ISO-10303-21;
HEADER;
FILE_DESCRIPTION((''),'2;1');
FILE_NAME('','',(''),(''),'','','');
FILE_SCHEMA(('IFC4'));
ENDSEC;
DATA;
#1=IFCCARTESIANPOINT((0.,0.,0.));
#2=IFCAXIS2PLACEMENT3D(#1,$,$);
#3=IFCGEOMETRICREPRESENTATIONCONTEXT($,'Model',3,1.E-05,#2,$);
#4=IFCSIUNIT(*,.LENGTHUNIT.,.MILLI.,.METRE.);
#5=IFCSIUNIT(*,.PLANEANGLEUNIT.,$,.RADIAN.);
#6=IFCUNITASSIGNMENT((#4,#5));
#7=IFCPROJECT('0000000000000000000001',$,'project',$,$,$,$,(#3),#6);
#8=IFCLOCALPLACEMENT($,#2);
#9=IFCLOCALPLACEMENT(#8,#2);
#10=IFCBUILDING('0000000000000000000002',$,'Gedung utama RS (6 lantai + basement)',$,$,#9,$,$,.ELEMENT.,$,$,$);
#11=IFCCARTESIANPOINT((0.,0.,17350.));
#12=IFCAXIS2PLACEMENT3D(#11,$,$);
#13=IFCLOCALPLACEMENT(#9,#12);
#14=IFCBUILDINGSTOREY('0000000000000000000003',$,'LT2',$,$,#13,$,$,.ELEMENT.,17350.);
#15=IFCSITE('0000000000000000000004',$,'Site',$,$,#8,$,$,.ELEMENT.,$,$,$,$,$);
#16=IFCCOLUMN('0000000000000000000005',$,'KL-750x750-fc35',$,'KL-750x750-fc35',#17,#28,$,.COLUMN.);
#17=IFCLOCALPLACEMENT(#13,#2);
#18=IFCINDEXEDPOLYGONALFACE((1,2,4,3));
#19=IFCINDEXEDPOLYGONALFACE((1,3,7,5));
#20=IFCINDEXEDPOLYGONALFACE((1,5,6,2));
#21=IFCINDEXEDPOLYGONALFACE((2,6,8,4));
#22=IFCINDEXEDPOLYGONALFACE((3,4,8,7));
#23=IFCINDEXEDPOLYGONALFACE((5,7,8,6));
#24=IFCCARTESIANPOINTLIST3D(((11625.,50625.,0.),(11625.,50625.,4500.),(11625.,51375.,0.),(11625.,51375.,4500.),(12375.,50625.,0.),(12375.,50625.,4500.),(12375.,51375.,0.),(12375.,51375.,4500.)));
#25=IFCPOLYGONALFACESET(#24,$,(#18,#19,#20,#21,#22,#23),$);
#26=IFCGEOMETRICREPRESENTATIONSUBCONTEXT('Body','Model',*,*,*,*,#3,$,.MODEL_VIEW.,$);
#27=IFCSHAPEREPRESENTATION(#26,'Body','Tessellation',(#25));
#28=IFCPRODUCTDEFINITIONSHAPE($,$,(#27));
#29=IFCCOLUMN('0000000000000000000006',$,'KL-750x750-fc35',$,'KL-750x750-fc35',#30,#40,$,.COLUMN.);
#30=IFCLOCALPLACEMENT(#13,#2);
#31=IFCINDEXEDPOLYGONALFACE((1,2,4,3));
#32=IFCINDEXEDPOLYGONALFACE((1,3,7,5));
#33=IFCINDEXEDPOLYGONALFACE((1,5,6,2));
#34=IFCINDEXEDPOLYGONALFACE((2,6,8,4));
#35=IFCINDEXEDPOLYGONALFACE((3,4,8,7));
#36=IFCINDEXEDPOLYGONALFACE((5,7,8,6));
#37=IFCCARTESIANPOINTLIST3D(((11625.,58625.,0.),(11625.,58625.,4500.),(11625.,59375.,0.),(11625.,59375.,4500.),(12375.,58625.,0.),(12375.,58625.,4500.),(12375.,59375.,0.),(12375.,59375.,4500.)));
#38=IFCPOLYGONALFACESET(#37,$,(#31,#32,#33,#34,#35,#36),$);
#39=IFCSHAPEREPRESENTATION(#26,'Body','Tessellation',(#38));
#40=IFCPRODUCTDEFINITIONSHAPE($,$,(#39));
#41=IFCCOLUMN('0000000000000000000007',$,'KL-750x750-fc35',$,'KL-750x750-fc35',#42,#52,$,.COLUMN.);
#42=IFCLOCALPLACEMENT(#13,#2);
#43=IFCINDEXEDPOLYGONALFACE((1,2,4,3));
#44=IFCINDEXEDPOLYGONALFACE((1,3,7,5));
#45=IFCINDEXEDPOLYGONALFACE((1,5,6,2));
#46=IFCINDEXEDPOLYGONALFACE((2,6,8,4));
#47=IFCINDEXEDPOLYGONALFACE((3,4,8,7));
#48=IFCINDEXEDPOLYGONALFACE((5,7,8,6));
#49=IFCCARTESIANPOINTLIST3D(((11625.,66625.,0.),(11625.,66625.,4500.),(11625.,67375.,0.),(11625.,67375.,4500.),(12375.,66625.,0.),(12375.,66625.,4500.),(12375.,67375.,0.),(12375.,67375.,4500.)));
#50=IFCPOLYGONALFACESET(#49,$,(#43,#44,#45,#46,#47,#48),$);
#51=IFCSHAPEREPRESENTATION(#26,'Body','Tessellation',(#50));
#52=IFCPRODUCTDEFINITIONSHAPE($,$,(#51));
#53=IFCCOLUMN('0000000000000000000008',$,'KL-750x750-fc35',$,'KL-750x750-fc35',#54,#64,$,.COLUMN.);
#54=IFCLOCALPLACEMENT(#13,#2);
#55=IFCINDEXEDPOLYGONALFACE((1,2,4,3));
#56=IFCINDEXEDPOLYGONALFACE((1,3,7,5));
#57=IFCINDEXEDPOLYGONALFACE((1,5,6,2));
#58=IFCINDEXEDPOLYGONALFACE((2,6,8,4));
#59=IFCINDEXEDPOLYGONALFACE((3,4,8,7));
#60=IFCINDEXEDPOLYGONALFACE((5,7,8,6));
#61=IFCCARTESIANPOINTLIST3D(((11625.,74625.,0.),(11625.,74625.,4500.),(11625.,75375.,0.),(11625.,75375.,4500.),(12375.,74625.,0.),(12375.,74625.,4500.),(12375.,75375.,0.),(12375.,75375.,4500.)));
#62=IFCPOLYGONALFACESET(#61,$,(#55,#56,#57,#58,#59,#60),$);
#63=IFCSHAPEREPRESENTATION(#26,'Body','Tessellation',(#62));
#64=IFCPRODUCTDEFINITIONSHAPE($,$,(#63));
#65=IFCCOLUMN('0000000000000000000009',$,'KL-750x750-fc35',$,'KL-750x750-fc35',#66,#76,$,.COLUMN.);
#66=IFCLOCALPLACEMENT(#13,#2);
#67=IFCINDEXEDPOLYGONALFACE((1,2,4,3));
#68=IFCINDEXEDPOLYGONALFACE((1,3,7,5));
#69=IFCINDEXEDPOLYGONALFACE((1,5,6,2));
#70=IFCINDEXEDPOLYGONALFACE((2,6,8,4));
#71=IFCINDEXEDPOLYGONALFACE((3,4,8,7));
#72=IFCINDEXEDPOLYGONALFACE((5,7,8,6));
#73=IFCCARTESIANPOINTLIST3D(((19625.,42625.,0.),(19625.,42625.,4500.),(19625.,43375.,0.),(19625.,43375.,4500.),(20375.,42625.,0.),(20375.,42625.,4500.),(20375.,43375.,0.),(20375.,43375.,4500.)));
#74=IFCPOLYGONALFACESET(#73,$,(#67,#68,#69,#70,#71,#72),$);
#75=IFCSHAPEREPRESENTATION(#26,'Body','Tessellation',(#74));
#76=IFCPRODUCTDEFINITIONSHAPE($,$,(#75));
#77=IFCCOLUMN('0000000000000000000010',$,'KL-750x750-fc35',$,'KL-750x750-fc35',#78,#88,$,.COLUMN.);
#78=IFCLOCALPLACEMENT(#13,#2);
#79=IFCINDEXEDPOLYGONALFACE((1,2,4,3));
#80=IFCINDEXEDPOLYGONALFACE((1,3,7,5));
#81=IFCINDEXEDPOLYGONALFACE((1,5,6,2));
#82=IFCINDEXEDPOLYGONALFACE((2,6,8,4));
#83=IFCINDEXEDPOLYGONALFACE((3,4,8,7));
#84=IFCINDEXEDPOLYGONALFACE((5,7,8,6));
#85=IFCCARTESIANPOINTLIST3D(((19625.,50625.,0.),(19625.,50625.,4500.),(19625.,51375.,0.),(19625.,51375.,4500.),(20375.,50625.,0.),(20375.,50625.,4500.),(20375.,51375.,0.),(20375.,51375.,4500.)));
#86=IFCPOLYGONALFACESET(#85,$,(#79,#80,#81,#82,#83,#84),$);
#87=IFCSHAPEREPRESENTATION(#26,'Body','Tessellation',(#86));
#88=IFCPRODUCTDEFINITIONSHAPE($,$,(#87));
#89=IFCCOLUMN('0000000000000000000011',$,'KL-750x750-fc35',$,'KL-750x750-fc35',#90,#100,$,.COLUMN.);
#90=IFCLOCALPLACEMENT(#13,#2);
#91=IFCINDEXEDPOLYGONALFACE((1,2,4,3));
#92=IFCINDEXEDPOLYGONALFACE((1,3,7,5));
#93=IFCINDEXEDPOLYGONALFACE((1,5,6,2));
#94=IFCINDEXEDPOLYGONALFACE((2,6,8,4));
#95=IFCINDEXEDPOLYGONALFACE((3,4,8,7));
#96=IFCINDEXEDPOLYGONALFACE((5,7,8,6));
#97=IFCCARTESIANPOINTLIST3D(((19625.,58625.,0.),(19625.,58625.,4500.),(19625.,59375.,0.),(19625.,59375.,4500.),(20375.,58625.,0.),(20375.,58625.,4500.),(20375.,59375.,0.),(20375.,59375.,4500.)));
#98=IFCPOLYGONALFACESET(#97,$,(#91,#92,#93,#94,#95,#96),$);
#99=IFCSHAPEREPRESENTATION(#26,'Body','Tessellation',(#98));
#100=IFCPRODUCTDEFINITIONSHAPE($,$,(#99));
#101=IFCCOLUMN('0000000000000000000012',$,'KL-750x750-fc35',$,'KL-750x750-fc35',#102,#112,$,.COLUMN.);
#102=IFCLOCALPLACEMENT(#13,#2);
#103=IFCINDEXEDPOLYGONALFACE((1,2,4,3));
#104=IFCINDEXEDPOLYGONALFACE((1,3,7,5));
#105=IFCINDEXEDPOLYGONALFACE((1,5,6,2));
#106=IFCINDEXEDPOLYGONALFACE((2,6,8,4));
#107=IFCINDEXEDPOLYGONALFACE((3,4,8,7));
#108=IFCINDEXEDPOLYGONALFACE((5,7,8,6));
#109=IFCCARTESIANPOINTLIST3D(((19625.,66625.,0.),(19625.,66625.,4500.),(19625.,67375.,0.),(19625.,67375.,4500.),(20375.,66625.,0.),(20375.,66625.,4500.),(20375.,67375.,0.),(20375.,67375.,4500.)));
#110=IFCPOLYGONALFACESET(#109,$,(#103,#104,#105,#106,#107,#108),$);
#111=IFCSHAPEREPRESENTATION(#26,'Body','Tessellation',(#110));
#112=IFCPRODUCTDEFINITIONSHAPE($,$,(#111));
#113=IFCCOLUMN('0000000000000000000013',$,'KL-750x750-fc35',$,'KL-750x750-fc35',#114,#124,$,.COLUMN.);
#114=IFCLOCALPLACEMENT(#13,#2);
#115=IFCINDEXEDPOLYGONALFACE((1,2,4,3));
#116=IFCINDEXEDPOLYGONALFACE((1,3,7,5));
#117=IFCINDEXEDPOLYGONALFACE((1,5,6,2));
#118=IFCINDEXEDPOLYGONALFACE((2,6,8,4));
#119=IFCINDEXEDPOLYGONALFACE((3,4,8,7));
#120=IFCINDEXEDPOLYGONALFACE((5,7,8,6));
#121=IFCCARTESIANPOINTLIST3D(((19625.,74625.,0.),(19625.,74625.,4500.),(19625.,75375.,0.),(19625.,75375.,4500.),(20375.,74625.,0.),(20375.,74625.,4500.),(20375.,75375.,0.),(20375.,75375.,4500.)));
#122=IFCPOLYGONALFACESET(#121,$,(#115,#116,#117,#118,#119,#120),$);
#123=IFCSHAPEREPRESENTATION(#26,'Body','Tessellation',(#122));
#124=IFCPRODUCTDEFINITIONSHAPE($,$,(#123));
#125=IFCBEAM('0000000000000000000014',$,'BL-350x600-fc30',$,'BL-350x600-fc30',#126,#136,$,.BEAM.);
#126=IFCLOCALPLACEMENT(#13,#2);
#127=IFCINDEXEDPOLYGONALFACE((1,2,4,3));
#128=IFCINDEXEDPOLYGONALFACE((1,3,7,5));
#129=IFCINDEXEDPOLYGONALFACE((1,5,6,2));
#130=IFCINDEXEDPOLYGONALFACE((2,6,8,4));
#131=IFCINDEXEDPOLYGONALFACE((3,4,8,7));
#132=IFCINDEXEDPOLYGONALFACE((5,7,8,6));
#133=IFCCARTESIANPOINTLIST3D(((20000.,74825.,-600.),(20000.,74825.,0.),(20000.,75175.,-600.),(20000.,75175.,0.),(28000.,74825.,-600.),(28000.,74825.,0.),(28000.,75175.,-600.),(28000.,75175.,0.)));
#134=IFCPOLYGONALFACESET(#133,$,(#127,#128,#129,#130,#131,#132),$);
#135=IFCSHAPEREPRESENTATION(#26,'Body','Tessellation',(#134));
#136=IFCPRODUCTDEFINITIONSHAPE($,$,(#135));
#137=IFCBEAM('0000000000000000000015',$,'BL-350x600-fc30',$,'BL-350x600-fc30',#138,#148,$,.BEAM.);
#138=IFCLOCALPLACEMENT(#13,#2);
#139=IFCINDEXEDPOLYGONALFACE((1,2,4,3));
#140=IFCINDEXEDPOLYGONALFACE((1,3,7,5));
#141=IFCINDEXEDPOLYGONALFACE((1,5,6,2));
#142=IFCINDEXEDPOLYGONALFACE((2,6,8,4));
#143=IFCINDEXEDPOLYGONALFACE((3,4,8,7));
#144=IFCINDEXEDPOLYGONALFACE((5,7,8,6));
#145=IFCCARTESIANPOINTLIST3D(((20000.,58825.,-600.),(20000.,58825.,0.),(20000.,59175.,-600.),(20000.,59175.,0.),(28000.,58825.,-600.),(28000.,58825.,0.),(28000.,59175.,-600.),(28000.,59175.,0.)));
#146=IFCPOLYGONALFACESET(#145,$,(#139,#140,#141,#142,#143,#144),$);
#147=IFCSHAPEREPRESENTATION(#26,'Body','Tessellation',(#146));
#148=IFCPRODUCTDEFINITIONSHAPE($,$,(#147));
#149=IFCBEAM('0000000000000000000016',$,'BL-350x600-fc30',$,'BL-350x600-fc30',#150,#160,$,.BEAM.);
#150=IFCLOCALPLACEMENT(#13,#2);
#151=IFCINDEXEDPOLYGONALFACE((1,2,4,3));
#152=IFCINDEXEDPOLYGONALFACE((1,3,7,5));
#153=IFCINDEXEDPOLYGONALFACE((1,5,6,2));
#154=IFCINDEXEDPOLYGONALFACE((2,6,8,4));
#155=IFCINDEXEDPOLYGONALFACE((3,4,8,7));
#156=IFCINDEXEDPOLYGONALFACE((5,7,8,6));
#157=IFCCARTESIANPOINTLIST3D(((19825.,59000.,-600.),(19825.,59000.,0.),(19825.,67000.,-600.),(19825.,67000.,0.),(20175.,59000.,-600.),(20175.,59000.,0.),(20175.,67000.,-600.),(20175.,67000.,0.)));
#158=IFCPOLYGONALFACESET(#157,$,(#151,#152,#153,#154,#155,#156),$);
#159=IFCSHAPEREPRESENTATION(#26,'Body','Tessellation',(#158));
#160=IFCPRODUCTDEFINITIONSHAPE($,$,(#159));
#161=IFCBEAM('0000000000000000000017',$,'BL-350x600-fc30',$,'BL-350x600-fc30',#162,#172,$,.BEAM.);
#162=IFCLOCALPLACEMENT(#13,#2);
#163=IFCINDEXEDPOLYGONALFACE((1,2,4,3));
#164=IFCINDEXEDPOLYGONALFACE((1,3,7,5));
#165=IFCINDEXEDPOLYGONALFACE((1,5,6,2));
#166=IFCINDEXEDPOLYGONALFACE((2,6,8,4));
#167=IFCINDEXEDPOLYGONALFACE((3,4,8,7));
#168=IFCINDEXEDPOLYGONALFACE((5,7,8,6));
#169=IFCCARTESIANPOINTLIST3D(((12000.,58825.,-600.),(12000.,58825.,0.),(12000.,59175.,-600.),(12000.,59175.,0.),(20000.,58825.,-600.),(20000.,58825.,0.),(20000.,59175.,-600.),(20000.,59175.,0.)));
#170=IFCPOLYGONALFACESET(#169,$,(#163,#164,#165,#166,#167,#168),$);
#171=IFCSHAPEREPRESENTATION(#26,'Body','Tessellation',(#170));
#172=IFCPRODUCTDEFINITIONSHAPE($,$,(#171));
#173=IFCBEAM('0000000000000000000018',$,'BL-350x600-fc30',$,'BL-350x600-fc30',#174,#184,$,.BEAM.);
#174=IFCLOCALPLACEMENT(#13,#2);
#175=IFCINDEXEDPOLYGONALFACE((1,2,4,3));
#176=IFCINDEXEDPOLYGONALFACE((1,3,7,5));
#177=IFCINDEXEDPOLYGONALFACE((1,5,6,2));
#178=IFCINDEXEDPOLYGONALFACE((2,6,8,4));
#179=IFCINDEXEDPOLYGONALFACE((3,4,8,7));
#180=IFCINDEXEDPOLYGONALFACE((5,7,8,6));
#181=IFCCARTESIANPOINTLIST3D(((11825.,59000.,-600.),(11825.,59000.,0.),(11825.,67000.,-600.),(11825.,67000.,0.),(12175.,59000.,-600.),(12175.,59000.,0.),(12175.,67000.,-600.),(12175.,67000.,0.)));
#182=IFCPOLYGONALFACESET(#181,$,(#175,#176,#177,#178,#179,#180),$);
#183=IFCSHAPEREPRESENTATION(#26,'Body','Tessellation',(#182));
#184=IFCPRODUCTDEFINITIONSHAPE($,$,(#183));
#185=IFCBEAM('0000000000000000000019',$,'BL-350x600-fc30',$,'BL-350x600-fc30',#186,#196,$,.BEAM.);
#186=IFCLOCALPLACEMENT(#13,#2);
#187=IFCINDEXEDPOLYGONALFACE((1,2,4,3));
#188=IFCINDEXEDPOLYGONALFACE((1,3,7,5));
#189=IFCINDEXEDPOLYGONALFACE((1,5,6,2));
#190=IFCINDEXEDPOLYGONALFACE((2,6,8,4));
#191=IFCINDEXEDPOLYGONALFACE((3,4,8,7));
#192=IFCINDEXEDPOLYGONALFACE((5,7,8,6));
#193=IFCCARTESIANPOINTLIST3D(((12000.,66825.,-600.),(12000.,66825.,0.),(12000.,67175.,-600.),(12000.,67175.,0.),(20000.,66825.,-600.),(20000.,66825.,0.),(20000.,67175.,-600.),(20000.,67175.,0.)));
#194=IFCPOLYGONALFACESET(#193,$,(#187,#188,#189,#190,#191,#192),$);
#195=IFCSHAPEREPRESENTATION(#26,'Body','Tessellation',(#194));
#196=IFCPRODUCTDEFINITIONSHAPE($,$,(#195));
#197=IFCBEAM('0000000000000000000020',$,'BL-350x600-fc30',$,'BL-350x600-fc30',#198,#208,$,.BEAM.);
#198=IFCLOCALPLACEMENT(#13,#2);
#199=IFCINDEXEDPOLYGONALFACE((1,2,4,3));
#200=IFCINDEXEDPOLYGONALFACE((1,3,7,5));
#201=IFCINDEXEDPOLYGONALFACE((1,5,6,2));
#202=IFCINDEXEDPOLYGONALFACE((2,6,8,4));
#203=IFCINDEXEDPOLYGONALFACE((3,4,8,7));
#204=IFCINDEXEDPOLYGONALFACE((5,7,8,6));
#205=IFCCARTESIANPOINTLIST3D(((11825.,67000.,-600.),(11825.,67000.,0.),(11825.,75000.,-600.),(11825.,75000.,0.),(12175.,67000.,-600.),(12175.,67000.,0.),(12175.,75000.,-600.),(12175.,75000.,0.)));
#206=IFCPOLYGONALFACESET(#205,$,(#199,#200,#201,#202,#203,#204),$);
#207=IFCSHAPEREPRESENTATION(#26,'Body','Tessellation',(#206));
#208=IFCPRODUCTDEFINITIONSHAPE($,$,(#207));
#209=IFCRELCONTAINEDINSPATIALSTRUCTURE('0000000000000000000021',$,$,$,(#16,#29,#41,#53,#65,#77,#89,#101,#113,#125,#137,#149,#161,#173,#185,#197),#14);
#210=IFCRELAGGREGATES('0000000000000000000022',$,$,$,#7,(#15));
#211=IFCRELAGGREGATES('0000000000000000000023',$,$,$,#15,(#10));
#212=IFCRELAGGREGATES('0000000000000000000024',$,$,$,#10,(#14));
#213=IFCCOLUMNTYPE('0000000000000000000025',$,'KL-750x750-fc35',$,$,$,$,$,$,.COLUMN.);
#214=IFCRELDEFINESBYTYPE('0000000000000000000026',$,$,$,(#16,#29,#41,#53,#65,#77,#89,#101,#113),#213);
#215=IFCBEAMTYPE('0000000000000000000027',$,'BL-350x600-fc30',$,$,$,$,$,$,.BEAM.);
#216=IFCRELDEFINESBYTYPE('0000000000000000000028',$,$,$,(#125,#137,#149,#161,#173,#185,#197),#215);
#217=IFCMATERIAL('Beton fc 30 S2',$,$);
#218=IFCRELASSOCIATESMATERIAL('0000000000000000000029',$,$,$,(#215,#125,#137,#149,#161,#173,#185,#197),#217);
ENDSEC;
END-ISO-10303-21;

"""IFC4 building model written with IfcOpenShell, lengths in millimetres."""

from ifc_helpers import new_model, si_unit, frame, origin, origin_2d, place, context, subcontext, project, spatial, rectangle, extrude, material, material_profile, profile_set, profile_usage, type_object, element, save


model = new_model("IFC4")

# Units and contexts
model_context = context("Model", 3, precision=1e-05, world=origin())
body_context = subcontext(model_context, "Body", "Model", "MODEL_VIEW")
ifc_project = project(units=[si_unit("LENGTHUNIT", "METRE", prefix="MILLI"), si_unit("PLANEANGLEUNIT", "RADIAN")], contexts=[model_context])

# Site, building, storey
site_placement = place(None, origin())
site = spatial("IfcSite", under=ifc_project, at=site_placement, Name="Site", CompositionType="ELEMENT")
building_placement = place(site_placement, origin())
building = spatial("IfcBuilding", under=site, at=building_placement, Name="Gedung utama RS (6 lantai + basement)", CompositionType="ELEMENT")
storey_placement = place(building_placement, frame((0.0, 0.0, 17350.0)))
storey = spatial("IfcBuildingStorey", under=building, at=storey_placement, Name="LT2", CompositionType="ELEMENT", Elevation=17350.0)

# Columns
ifc_material_profile_1 = material_profile(None, rectangle(XDim=750.0, YDim=750.0, at=origin_2d()), Name="KL-750x750-fc35")
ifc_profile_set_1 = profile_set([ifc_material_profile_1], Name="KL-750x750-fc35")
ifc_profile_usage_1 = profile_usage(ifc_profile_set_1, cardinal=5)
column_type = type_object("IfcColumnType", Name="KL-750x750-fc35", PredefinedType="COLUMN", material=ifc_profile_set_1)
for number, where, z_axis, x_axis, name in (
    (1, (12000.0, 51000.0, 0.0), (0.0, 0.0, 1.0), (1.0, 0.0, 0.0), "KL-750x750-fc35"),
    (2, (12000.0, 59000.0, 0.0), (0.0, 0.0, 1.0), (1.0, 0.0, 0.0), "KL-750x750-fc35"),
    (3, (12000.0, 67000.0, 0.0), (0.0, 0.0, 1.0), (1.0, 0.0, 0.0), "KL-750x750-fc35"),
    (4, (12000.0, 75000.0, 0.0), (0.0, 0.0, 1.0), (1.0, 0.0, 0.0), "KL-750x750-fc35"),
    (5, (20000.0, 43000.0, 0.0), (0.0, 0.0, 1.0), (1.0, 0.0, 0.0), "KL-750x750-fc35"),
    (6, (20000.0, 51000.0, 0.0), (0.0, 0.0, 1.0), (1.0, 0.0, 0.0), "KL-750x750-fc35"),
    (7, (20000.0, 59000.0, 0.0), (0.0, 0.0, 1.0), (1.0, 0.0, 0.0), "KL-750x750-fc35"),
    (8, (20000.0, 67000.0, 0.0), (0.0, 0.0, 1.0), (1.0, 0.0, 0.0), "KL-750x750-fc35"),
    (9, (20000.0, 75000.0, 0.0), (0.0, 0.0, 1.0), (1.0, 0.0, 0.0), "KL-750x750-fc35"),
):
    element("IfcColumn", number, at=place(storey_placement, frame(where, z_axis=z_axis, x_axis=x_axis)), inside=storey, type_object=column_type, material=ifc_profile_usage_1, Name=name, ObjectType="KL-750x750-fc35", PredefinedType="COLUMN", context=body_context, shape_type="SweptSolid", body=[
        extrude(rectangle(XDim=750.0, YDim=750.0, at=origin_2d()), origin(), (0.0, 0.0, 1.0), 4500.0),
    ])

# Beams
ifc_material_1 = material(Name="Beton fc 30 S2")
ifc_material_profile_2 = material_profile(ifc_material_1, rectangle(XDim=350.0, YDim=600.0, at=origin_2d()), Name="BL-350x600-fc30")
ifc_profile_set_2 = profile_set([ifc_material_profile_2], Name="BL-350x600-fc30")
ifc_profile_usage_2 = profile_usage(ifc_profile_set_2, cardinal=8)
beam_type = type_object("IfcBeamType", Name="BL-350x600-fc30", PredefinedType="BEAM", material=ifc_profile_set_2)
for number, where, name in (
    (10, (20000.0, 75000.0, -300.0), "BL-350x600-fc30"),
    (11, (20000.0, 59000.0, -300.0), "BL-350x600-fc30"),
):
    element("IfcBeam", number, at=place(storey_placement, frame(where)), inside=storey, type_object=beam_type, material=ifc_profile_usage_2, Name=name, ObjectType="BL-350x600-fc30", PredefinedType="BEAM", context=body_context, shape_type="SweptSolid", body=[
        extrude(rectangle(XDim=350.0, YDim=600.0, at=origin_2d()), frame((0.0, 0.0, 0.0), z_axis=(1.0, 0.0, 0.0), x_axis=(0.0, 1.0, 0.0)), (0.0, 0.0, 1.0), 8000.0),
    ])
beam_1_placement = place(storey_placement, frame((20000.0, 59000.0, -300.0)))
element("IfcBeam", 12, at=beam_1_placement, inside=storey, type_object=beam_type, material=ifc_profile_usage_2, Name="BL-350x600-fc30", ObjectType="BL-350x600-fc30", PredefinedType="BEAM", context=body_context, shape_type="SweptSolid", body=[
    extrude(rectangle(XDim=350.0, YDim=600.0, at=origin_2d()), frame((0.0, 0.0, 0.0), z_axis=(0.0, 1.0, 0.0), x_axis=(-1.0, 0.0, 0.0)), (0.0, 0.0, 1.0), 8000.0),
])
beam_2_placement = place(storey_placement, frame((12000.0, 59000.0, -300.0)))
element("IfcBeam", 13, at=beam_2_placement, inside=storey, type_object=beam_type, material=ifc_profile_usage_2, Name="BL-350x600-fc30", ObjectType="BL-350x600-fc30", PredefinedType="BEAM", context=body_context, shape_type="SweptSolid", body=[
    extrude(rectangle(XDim=350.0, YDim=600.0, at=origin_2d()), frame((0.0, 0.0, 0.0), z_axis=(1.0, 0.0, 0.0), x_axis=(0.0, 1.0, 0.0)), (0.0, 0.0, 1.0), 8000.0),
])
beam_3_placement = place(storey_placement, frame((12000.0, 59000.0, -300.0)))
element("IfcBeam", 14, at=beam_3_placement, inside=storey, type_object=beam_type, material=ifc_profile_usage_2, Name="BL-350x600-fc30", ObjectType="BL-350x600-fc30", PredefinedType="BEAM", context=body_context, shape_type="SweptSolid", body=[
    extrude(rectangle(XDim=350.0, YDim=600.0, at=origin_2d()), frame((0.0, 0.0, 0.0), z_axis=(0.0, 1.0, 0.0), x_axis=(-1.0, 0.0, 0.0)), (0.0, 0.0, 1.0), 8000.0),
])
beam_4_placement = place(storey_placement, frame((12000.0, 67000.0, -300.0)))
element("IfcBeam", 15, at=beam_4_placement, inside=storey, type_object=beam_type, material=ifc_profile_usage_2, Name="BL-350x600-fc30", ObjectType="BL-350x600-fc30", PredefinedType="BEAM", context=body_context, shape_type="SweptSolid", body=[
    extrude(rectangle(XDim=350.0, YDim=600.0, at=origin_2d()), frame((0.0, 0.0, 0.0), z_axis=(1.0, 0.0, 0.0), x_axis=(0.0, 1.0, 0.0)), (0.0, 0.0, 1.0), 8000.0),
])
beam_5_placement = place(storey_placement, frame((12000.0, 67000.0, -300.0)))
element("IfcBeam", 16, at=beam_5_placement, inside=storey, type_object=beam_type, material=ifc_profile_usage_2, Name="BL-350x600-fc30", ObjectType="BL-350x600-fc30", PredefinedType="BEAM", context=body_context, shape_type="SweptSolid", body=[
    extrude(rectangle(XDim=350.0, YDim=600.0, at=origin_2d()), frame((0.0, 0.0, 0.0), z_axis=(0.0, 1.0, 0.0), x_axis=(-1.0, 0.0, 0.0)), (0.0, 0.0, 1.0), 8000.0),
])

save(model, "model.ifc")
